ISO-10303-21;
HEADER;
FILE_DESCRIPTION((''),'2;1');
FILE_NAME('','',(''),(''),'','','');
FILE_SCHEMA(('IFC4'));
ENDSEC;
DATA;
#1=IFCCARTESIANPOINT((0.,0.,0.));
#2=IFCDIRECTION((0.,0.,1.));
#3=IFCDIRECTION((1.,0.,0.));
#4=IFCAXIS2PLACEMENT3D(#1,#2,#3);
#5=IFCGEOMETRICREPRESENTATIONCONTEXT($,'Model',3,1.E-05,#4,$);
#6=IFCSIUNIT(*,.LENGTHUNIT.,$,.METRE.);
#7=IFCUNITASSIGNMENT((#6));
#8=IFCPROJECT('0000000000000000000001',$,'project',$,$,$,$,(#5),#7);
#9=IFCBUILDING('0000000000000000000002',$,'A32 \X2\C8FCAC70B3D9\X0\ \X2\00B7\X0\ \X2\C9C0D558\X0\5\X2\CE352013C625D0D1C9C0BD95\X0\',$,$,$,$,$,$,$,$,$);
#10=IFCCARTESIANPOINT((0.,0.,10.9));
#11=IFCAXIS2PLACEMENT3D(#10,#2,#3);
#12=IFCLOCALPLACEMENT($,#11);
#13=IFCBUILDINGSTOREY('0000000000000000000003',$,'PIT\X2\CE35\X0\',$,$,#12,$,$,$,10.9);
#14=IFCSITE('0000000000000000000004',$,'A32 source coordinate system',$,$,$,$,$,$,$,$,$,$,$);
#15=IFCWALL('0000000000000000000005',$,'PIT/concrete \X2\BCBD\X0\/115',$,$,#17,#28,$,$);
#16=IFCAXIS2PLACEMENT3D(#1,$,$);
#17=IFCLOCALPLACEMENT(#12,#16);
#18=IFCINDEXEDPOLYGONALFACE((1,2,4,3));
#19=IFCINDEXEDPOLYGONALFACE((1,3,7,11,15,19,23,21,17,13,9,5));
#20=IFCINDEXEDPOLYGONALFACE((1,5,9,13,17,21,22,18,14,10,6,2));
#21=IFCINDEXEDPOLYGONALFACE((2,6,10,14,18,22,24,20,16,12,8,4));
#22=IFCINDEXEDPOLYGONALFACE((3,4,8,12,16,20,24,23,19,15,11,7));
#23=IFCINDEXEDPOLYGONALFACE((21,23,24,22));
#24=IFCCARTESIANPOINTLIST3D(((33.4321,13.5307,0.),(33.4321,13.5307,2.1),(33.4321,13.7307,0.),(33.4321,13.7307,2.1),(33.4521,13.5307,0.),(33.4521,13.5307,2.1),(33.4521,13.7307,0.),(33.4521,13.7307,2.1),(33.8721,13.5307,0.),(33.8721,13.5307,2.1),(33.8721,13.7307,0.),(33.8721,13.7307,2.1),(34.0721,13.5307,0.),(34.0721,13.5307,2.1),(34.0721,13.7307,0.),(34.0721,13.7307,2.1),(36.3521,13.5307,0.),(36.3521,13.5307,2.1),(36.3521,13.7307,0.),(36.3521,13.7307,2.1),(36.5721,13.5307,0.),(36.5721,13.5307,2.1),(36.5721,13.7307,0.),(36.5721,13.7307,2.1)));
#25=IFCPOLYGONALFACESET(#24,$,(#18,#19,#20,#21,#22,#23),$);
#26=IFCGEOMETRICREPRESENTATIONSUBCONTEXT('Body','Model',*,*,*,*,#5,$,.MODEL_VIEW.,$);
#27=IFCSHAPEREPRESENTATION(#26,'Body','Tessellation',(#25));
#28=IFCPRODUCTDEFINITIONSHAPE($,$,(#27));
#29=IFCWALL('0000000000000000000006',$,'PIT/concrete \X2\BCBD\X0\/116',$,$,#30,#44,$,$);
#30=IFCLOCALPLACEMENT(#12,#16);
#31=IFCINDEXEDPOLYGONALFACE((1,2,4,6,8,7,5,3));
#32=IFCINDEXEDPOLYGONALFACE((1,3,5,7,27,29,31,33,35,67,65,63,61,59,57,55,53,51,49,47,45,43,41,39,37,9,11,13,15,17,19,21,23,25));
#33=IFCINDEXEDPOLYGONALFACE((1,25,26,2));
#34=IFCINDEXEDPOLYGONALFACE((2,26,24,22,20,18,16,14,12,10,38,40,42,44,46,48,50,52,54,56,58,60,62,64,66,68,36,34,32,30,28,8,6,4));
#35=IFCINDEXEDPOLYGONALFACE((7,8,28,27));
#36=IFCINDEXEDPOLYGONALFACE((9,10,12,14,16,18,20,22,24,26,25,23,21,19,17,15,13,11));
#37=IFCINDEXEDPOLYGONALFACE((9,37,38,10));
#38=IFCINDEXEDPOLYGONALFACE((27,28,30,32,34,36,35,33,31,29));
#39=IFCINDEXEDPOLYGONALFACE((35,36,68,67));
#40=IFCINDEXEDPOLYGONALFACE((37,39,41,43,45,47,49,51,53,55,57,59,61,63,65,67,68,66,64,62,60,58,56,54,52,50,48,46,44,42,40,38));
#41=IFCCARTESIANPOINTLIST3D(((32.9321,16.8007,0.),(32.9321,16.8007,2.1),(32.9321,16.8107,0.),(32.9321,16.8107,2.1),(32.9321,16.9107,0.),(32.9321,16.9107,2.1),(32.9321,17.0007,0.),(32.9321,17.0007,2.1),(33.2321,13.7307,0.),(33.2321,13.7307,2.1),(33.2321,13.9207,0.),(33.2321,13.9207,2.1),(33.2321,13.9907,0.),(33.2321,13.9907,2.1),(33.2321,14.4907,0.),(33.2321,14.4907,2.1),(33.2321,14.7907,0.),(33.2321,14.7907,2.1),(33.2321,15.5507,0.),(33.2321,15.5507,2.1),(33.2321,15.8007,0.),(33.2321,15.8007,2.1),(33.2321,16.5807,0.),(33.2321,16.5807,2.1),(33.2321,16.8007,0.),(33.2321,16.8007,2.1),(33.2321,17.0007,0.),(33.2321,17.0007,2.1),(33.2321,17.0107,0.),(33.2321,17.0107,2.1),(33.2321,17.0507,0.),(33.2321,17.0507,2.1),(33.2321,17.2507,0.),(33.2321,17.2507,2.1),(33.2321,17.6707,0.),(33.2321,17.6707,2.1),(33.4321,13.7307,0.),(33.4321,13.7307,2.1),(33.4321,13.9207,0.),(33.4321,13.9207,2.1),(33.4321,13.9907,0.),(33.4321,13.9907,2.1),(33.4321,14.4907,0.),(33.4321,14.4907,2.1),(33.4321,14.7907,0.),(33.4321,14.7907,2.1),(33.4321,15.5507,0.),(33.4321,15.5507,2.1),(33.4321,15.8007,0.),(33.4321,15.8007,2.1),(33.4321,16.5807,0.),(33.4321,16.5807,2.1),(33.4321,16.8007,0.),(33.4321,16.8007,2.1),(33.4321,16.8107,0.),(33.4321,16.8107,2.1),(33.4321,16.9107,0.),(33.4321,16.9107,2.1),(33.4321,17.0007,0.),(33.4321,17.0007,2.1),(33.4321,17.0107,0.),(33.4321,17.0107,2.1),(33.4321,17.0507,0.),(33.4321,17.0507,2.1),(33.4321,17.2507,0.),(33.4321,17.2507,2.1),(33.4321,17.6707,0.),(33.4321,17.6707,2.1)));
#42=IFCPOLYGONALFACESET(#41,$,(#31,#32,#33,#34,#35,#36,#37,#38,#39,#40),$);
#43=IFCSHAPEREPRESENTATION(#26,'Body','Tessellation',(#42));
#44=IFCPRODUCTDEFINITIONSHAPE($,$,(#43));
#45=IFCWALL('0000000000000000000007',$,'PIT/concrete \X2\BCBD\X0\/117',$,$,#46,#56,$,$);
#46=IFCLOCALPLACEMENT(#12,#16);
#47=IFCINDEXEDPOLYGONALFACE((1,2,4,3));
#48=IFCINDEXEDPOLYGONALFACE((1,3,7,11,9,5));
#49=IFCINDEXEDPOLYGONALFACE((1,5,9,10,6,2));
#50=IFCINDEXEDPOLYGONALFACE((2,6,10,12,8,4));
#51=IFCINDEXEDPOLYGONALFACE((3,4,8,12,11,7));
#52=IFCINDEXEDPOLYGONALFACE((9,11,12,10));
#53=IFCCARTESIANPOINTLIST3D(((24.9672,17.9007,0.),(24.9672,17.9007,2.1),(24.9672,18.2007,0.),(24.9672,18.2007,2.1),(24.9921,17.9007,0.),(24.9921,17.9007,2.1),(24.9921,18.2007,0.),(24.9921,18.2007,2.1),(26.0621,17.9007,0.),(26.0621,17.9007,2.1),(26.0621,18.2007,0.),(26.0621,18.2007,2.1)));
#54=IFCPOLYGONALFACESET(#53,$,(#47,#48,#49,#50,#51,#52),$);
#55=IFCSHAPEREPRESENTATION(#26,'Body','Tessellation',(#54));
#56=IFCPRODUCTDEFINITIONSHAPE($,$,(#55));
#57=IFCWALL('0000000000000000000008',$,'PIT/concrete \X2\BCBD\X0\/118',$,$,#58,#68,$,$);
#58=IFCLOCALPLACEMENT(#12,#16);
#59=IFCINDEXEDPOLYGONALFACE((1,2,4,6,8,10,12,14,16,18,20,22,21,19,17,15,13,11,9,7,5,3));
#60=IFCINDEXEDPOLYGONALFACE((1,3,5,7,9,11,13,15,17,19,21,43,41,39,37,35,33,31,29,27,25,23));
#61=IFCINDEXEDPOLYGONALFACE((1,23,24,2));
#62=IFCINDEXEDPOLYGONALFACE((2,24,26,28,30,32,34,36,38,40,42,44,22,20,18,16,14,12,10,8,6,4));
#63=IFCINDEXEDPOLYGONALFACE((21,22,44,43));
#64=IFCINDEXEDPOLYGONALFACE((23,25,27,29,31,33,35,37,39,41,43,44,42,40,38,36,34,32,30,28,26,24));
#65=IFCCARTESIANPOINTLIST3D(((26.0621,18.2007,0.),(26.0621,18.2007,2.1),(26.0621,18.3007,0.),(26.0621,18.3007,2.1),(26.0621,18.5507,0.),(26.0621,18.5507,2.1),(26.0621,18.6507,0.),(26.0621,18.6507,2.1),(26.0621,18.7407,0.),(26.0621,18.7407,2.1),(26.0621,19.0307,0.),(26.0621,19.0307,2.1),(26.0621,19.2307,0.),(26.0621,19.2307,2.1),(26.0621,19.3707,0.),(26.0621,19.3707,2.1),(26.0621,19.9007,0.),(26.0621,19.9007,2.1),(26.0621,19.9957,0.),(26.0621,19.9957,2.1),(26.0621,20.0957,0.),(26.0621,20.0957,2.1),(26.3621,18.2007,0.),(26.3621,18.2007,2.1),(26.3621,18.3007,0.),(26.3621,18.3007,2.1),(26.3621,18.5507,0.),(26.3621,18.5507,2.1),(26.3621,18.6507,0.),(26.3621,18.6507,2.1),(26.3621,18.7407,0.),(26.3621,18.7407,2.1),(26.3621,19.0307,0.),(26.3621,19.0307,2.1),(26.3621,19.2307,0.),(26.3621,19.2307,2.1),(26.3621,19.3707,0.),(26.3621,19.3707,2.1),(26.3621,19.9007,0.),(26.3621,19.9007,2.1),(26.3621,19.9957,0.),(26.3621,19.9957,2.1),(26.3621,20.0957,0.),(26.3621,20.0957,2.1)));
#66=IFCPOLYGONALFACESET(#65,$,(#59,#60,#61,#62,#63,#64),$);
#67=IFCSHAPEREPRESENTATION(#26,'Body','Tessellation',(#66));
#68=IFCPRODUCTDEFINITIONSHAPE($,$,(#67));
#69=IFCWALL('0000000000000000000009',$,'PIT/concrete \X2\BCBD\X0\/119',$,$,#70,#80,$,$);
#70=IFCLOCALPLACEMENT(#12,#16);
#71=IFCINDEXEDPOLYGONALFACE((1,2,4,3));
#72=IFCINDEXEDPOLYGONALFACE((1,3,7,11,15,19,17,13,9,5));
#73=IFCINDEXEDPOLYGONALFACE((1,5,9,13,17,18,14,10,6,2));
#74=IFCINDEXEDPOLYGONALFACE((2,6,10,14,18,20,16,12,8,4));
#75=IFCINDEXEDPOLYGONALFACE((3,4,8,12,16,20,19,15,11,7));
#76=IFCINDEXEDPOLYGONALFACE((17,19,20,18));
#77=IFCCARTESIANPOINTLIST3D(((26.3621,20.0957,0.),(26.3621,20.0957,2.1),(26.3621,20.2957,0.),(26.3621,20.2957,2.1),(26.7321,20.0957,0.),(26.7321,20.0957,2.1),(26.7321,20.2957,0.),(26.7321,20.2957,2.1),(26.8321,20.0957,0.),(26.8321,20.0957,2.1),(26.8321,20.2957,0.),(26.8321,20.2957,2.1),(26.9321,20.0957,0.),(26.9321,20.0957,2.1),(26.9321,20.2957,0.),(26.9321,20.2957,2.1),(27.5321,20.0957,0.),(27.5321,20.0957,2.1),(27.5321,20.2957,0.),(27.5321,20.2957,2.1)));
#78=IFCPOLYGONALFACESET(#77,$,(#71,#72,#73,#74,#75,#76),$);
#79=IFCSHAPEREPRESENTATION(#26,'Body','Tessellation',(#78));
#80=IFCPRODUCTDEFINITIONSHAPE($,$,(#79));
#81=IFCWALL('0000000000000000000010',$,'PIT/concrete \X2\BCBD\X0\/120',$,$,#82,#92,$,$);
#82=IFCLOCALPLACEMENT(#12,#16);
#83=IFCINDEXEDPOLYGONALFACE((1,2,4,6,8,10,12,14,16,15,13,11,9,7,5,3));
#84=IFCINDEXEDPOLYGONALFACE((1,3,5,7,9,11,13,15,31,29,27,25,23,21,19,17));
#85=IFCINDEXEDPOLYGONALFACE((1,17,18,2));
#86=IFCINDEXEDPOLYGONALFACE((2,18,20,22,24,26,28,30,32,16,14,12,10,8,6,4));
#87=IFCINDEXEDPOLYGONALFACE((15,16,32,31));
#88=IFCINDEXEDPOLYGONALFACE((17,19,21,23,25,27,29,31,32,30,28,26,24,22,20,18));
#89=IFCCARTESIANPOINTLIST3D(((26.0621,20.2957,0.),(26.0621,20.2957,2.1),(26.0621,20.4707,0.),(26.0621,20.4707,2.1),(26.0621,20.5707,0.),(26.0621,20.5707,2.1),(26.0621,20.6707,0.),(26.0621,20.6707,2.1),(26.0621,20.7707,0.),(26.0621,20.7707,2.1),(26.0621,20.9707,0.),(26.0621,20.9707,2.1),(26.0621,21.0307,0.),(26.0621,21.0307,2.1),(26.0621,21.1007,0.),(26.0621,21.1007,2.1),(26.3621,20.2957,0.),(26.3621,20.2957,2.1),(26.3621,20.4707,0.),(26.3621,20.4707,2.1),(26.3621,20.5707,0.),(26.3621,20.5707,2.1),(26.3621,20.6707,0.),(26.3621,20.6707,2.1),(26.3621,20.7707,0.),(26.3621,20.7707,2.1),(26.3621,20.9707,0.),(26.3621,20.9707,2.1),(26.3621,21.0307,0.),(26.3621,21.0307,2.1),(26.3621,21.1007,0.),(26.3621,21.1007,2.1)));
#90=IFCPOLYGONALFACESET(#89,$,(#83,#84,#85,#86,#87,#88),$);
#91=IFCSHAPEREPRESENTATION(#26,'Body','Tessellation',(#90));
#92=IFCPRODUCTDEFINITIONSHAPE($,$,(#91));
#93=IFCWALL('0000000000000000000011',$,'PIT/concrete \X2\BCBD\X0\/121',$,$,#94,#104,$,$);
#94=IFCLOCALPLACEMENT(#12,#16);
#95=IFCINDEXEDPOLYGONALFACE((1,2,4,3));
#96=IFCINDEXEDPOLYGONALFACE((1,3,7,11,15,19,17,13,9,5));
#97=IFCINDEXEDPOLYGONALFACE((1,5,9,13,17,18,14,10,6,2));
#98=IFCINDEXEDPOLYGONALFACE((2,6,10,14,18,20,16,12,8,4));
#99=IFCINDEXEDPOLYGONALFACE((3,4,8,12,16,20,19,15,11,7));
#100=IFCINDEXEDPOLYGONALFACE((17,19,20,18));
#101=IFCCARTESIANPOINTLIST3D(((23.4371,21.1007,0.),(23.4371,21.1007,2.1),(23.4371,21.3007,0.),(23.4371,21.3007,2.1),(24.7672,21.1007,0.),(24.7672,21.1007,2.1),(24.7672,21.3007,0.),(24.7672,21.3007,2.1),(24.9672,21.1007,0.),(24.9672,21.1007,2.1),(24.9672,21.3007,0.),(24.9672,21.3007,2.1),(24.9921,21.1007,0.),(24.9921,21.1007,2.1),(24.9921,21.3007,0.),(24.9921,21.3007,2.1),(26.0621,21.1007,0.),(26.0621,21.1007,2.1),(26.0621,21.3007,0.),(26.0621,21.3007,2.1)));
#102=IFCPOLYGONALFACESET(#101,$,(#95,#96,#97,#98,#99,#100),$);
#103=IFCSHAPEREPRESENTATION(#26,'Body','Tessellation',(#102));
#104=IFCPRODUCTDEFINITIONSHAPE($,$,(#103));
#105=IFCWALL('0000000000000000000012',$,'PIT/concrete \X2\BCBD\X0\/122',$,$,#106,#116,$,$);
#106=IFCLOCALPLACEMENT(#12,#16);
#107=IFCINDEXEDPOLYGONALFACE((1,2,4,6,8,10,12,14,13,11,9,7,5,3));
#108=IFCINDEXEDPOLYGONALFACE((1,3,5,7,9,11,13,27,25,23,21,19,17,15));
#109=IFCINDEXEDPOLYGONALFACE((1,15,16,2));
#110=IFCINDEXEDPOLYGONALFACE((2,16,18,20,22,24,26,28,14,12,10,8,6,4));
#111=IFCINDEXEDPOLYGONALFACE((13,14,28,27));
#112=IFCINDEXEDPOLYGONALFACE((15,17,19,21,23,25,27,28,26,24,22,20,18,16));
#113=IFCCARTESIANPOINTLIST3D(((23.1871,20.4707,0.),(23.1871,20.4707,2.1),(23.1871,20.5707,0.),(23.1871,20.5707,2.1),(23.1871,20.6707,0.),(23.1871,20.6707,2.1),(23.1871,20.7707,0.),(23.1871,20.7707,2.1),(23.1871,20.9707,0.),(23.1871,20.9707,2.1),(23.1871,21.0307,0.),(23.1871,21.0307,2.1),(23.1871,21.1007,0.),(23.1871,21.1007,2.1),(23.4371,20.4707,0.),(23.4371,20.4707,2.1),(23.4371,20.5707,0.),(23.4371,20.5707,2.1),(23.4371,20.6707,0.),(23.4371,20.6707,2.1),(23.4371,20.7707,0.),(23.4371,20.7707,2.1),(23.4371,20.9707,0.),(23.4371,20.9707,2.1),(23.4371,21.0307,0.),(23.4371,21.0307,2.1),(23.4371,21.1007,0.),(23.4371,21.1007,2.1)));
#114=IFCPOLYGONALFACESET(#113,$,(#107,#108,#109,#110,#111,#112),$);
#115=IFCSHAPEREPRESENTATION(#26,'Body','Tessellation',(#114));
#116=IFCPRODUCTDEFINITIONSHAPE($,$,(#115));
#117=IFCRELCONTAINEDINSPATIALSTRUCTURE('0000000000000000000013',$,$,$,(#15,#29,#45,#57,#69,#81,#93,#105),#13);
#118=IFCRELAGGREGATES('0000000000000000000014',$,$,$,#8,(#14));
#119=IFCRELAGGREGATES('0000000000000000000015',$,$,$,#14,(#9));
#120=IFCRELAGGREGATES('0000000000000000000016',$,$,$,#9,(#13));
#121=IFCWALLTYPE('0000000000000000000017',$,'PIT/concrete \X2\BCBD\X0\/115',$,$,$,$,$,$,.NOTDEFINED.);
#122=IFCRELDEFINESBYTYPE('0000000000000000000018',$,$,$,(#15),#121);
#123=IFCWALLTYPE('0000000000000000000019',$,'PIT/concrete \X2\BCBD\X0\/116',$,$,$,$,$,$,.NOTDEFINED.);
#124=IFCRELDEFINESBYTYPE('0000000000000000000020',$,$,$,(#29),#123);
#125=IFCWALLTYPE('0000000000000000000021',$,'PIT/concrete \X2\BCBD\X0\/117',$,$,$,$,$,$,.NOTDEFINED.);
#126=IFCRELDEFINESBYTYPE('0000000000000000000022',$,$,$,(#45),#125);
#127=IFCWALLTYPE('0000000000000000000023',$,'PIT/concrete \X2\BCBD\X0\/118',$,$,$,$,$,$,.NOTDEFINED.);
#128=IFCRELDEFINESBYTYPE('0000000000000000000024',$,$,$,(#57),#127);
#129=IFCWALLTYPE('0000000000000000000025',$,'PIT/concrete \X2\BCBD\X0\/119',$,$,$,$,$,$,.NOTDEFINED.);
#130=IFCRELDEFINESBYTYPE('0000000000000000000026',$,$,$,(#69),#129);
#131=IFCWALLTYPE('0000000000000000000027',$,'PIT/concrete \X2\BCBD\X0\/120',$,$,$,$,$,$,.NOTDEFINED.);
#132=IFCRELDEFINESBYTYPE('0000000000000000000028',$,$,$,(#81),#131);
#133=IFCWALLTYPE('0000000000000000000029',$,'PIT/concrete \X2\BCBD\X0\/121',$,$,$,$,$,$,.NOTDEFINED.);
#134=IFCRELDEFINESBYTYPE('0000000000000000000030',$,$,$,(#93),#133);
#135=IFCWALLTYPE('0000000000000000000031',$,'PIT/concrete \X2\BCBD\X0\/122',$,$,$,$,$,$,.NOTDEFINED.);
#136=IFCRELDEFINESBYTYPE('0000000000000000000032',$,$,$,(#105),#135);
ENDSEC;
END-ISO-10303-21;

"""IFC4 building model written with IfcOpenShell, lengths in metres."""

from ifc_helpers import new_model, si_unit, frame, origin, origin_with_axes, place, context, subcontext, project, spatial, polyline, outline, extrude, source, transform, mapped, type_object, type_shapes, element, save


model = new_model("IFC4")

# Units and contexts
model_context = context("Model", 3, precision=1e-05, world=origin_with_axes())
body_context = subcontext(model_context, "Body", "Model", "MODEL_VIEW")
ifc_project = project(units=[si_unit("LENGTHUNIT", "METRE")], contexts=[model_context])

# Site, building, storey
site = spatial("IfcSite", under=ifc_project, Name="A32 source coordinate system")
building = spatial("IfcBuilding", under=site, Name="A32 주거동 · 지하5층–옥탑지붕")
storey_placement = place(None, frame((0.0, 0.0, 10.9), z_axis=(0.0, 0.0, 1.0), x_axis=(1.0, 0.0, 0.0)))
storey = spatial("IfcBuildingStorey", under=building, at=storey_placement, Name="PIT층", Elevation=10.9)

# Walls
wall_type_1 = type_object("IfcWallType", Name="PIT/concrete 벽/115", PredefinedType="NOTDEFINED")
shared_shape_1 = source(origin(), body_context, "Body", "SweptSolid", [
    extrude(outline(polyline([(33.8721, 13.7307), (34.0721, 13.7307), (36.3521, 13.7307), (36.5721, 13.7307), (36.5721, 13.5307), (36.3521, 13.5307), (34.0721, 13.5307), (33.8721, 13.5307), (33.4521, 13.5307), (33.4321, 13.5307), (33.4321, 13.7307), (33.4521, 13.7307), (33.8721, 13.7307)])), origin(), (0.0, 0.0, 1.0), 2.1),
])
type_shapes(wall_type_1, [shared_shape_1])
wall_1_placement = place(storey_placement, origin_with_axes())
element("IfcWall", 1, at=wall_1_placement, inside=storey, type_object=wall_type_1, Name="PIT/concrete 벽/115", context=body_context, shape_type="MappedRepresentation", body=[
    mapped(shared_shape_1, transform((0.0, 0.0, 0.0), scale=1.0)),
])
wall_type_2 = type_object("IfcWallType", Name="PIT/concrete 벽/116", PredefinedType="NOTDEFINED")
shared_shape_2 = source(origin(), body_context, "Body", "SweptSolid", [
    extrude(outline(polyline([(33.2321, 13.9907), (33.2321, 14.4907), (33.2321, 14.7907), (33.2321, 15.5507), (33.2321, 15.8007), (33.2321, 16.5807), (33.2321, 16.8007), (32.9321, 16.8007), (32.9321, 16.8107), (32.9321, 16.9107), (32.9321, 17.0007), (33.2321, 17.0007), (33.2321, 17.0107), (33.2321, 17.0507), (33.2321, 17.2507), (33.2321, 17.6707), (33.4321, 17.6707), (33.4321, 17.2507), (33.4321, 17.0507), (33.4321, 17.0107), (33.4321, 17.0007), (33.4321, 16.9107), (33.4321, 16.8107), (33.4321, 16.8007), (33.4321, 16.5807), (33.4321, 15.8007), (33.4321, 15.5507), (33.4321, 14.7907), (33.4321, 14.4907), (33.4321, 13.9907), (33.4321, 13.9207), (33.4321, 13.7307), (33.2321, 13.7307), (33.2321, 13.9207), (33.2321, 13.9907)])), origin(), (0.0, 0.0, 1.0), 2.1),
])
type_shapes(wall_type_2, [shared_shape_2])
wall_2_placement = place(storey_placement, origin_with_axes())
element("IfcWall", 2, at=wall_2_placement, inside=storey, type_object=wall_type_2, Name="PIT/concrete 벽/116", context=body_context, shape_type="MappedRepresentation", body=[
    mapped(shared_shape_2, transform((0.0, 0.0, 0.0), scale=1.0)),
])
wall_type_3 = type_object("IfcWallType", Name="PIT/concrete 벽/117", PredefinedType="NOTDEFINED")
shared_shape_3 = source(origin(), body_context, "Body", "SweptSolid", [
    extrude(outline(polyline([(26.0621, 18.2007), (26.0621, 17.9007), (24.9921, 17.9007), (24.9672, 17.9007), (24.9672, 18.2007), (24.9921, 18.2007), (26.0621, 18.2007)])), origin(), (0.0, 0.0, 1.0), 2.1),
])
type_shapes(wall_type_3, [shared_shape_3])
wall_3_placement = place(storey_placement, origin_with_axes())
element("IfcWall", 3, at=wall_3_placement, inside=storey, type_object=wall_type_3, Name="PIT/concrete 벽/117", context=body_context, shape_type="MappedRepresentation", body=[
    mapped(shared_shape_3, transform((0.0, 0.0, 0.0), scale=1.0)),
])
wall_type_4 = type_object("IfcWallType", Name="PIT/concrete 벽/118", PredefinedType="NOTDEFINED")
shared_shape_4 = source(origin(), body_context, "Body", "SweptSolid", [
    extrude(outline(polyline([(26.0621, 18.6507), (26.0621, 18.7407), (26.0621, 19.0307), (26.0621, 19.2307), (26.0621, 19.3707), (26.0621, 19.9007), (26.0621, 19.9957), (26.0621, 20.0957), (26.3621, 20.0957), (26.3621, 19.9957), (26.3621, 19.9007), (26.3621, 19.3707), (26.3621, 19.2307), (26.3621, 19.0307), (26.3621, 18.7407), (26.3621, 18.6507), (26.3621, 18.5507), (26.3621, 18.3007), (26.3621, 18.2007), (26.0621, 18.2007), (26.0621, 18.3007), (26.0621, 18.5507), (26.0621, 18.6507)])), origin(), (0.0, 0.0, 1.0), 2.1),
])
type_shapes(wall_type_4, [shared_shape_4])
wall_4_placement = place(storey_placement, origin_with_axes())
element("IfcWall", 4, at=wall_4_placement, inside=storey, type_object=wall_type_4, Name="PIT/concrete 벽/118", context=body_context, shape_type="MappedRepresentation", body=[
    mapped(shared_shape_4, transform((0.0, 0.0, 0.0), scale=1.0)),
])
wall_type_5 = type_object("IfcWallType", Name="PIT/concrete 벽/119", PredefinedType="NOTDEFINED")
shared_shape_5 = source(origin(), body_context, "Body", "SweptSolid", [
    extrude(outline(polyline([(26.8321, 20.2957), (26.9321, 20.2957), (27.5321, 20.2957), (27.5321, 20.0957), (26.9321, 20.0957), (26.8321, 20.0957), (26.7321, 20.0957), (26.3621, 20.0957), (26.3621, 20.2957), (26.7321, 20.2957), (26.8321, 20.2957)])), origin(), (0.0, 0.0, 1.0), 2.1),
])
type_shapes(wall_type_5, [shared_shape_5])
wall_5_placement = place(storey_placement, origin_with_axes())
element("IfcWall", 5, at=wall_5_placement, inside=storey, type_object=wall_type_5, Name="PIT/concrete 벽/119", context=body_context, shape_type="MappedRepresentation", body=[
    mapped(shared_shape_5, transform((0.0, 0.0, 0.0), scale=1.0)),
])
wall_type_6 = type_object("IfcWallType", Name="PIT/concrete 벽/120", PredefinedType="NOTDEFINED")
shared_shape_6 = source(origin(), body_context, "Body", "SweptSolid", [
    extrude(outline(polyline([(26.0621, 20.5707), (26.0621, 20.6707), (26.0621, 20.7707), (26.0621, 20.9707), (26.0621, 21.0307), (26.0621, 21.1007), (26.3621, 21.1007), (26.3621, 21.0307), (26.3621, 20.9707), (26.3621, 20.7707), (26.3621, 20.6707), (26.3621, 20.5707), (26.3621, 20.4707), (26.3621, 20.2957), (26.0621, 20.2957), (26.0621, 20.4707), (26.0621, 20.5707)])), origin(), (0.0, 0.0, 1.0), 2.1),
])
type_shapes(wall_type_6, [shared_shape_6])
wall_6_placement = place(storey_placement, origin_with_axes())
element("IfcWall", 6, at=wall_6_placement, inside=storey, type_object=wall_type_6, Name="PIT/concrete 벽/120", context=body_context, shape_type="MappedRepresentation", body=[
    mapped(shared_shape_6, transform((0.0, 0.0, 0.0), scale=1.0)),
])
wall_type_7 = type_object("IfcWallType", Name="PIT/concrete 벽/121", PredefinedType="NOTDEFINED")
shared_shape_7 = source(origin(), body_context, "Body", "SweptSolid", [
    extrude(outline(polyline([(24.7672, 21.1007), (23.4371, 21.1007), (23.4371, 21.3007), (24.7672, 21.3007), (24.9672, 21.3007), (24.9921, 21.3007), (26.0621, 21.3007), (26.0621, 21.1007), (24.9921, 21.1007), (24.9672, 21.1007), (24.7672, 21.1007)])), origin(), (0.0, 0.0, 1.0), 2.1),
])
type_shapes(wall_type_7, [shared_shape_7])
wall_7_placement = place(storey_placement, origin_with_axes())
element("IfcWall", 7, at=wall_7_placement, inside=storey, type_object=wall_type_7, Name="PIT/concrete 벽/121", context=body_context, shape_type="MappedRepresentation", body=[
    mapped(shared_shape_7, transform((0.0, 0.0, 0.0), scale=1.0)),
])
wall_type_8 = type_object("IfcWallType", Name="PIT/concrete 벽/122", PredefinedType="NOTDEFINED")
shared_shape_8 = source(origin(), body_context, "Body", "SweptSolid", [
    extrude(outline(polyline([(23.4371, 20.7707), (23.4371, 20.6707), (23.4371, 20.5707), (23.4371, 20.4707), (23.1871, 20.4707), (23.1871, 20.5707), (23.1871, 20.6707), (23.1871, 20.7707), (23.1871, 20.9707), (23.1871, 21.0307), (23.1871, 21.1007), (23.4371, 21.1007), (23.4371, 21.0307), (23.4371, 20.9707), (23.4371, 20.7707)])), origin(), (0.0, 0.0, 1.0), 2.1),
])
type_shapes(wall_type_8, [shared_shape_8])
wall_8_placement = place(storey_placement, origin_with_axes())
element("IfcWall", 8, at=wall_8_placement, inside=storey, type_object=wall_type_8, Name="PIT/concrete 벽/122", context=body_context, shape_type="MappedRepresentation", body=[
    mapped(shared_shape_8, transform((0.0, 0.0, 0.0), scale=1.0)),
])

save(model, "model.ifc")
